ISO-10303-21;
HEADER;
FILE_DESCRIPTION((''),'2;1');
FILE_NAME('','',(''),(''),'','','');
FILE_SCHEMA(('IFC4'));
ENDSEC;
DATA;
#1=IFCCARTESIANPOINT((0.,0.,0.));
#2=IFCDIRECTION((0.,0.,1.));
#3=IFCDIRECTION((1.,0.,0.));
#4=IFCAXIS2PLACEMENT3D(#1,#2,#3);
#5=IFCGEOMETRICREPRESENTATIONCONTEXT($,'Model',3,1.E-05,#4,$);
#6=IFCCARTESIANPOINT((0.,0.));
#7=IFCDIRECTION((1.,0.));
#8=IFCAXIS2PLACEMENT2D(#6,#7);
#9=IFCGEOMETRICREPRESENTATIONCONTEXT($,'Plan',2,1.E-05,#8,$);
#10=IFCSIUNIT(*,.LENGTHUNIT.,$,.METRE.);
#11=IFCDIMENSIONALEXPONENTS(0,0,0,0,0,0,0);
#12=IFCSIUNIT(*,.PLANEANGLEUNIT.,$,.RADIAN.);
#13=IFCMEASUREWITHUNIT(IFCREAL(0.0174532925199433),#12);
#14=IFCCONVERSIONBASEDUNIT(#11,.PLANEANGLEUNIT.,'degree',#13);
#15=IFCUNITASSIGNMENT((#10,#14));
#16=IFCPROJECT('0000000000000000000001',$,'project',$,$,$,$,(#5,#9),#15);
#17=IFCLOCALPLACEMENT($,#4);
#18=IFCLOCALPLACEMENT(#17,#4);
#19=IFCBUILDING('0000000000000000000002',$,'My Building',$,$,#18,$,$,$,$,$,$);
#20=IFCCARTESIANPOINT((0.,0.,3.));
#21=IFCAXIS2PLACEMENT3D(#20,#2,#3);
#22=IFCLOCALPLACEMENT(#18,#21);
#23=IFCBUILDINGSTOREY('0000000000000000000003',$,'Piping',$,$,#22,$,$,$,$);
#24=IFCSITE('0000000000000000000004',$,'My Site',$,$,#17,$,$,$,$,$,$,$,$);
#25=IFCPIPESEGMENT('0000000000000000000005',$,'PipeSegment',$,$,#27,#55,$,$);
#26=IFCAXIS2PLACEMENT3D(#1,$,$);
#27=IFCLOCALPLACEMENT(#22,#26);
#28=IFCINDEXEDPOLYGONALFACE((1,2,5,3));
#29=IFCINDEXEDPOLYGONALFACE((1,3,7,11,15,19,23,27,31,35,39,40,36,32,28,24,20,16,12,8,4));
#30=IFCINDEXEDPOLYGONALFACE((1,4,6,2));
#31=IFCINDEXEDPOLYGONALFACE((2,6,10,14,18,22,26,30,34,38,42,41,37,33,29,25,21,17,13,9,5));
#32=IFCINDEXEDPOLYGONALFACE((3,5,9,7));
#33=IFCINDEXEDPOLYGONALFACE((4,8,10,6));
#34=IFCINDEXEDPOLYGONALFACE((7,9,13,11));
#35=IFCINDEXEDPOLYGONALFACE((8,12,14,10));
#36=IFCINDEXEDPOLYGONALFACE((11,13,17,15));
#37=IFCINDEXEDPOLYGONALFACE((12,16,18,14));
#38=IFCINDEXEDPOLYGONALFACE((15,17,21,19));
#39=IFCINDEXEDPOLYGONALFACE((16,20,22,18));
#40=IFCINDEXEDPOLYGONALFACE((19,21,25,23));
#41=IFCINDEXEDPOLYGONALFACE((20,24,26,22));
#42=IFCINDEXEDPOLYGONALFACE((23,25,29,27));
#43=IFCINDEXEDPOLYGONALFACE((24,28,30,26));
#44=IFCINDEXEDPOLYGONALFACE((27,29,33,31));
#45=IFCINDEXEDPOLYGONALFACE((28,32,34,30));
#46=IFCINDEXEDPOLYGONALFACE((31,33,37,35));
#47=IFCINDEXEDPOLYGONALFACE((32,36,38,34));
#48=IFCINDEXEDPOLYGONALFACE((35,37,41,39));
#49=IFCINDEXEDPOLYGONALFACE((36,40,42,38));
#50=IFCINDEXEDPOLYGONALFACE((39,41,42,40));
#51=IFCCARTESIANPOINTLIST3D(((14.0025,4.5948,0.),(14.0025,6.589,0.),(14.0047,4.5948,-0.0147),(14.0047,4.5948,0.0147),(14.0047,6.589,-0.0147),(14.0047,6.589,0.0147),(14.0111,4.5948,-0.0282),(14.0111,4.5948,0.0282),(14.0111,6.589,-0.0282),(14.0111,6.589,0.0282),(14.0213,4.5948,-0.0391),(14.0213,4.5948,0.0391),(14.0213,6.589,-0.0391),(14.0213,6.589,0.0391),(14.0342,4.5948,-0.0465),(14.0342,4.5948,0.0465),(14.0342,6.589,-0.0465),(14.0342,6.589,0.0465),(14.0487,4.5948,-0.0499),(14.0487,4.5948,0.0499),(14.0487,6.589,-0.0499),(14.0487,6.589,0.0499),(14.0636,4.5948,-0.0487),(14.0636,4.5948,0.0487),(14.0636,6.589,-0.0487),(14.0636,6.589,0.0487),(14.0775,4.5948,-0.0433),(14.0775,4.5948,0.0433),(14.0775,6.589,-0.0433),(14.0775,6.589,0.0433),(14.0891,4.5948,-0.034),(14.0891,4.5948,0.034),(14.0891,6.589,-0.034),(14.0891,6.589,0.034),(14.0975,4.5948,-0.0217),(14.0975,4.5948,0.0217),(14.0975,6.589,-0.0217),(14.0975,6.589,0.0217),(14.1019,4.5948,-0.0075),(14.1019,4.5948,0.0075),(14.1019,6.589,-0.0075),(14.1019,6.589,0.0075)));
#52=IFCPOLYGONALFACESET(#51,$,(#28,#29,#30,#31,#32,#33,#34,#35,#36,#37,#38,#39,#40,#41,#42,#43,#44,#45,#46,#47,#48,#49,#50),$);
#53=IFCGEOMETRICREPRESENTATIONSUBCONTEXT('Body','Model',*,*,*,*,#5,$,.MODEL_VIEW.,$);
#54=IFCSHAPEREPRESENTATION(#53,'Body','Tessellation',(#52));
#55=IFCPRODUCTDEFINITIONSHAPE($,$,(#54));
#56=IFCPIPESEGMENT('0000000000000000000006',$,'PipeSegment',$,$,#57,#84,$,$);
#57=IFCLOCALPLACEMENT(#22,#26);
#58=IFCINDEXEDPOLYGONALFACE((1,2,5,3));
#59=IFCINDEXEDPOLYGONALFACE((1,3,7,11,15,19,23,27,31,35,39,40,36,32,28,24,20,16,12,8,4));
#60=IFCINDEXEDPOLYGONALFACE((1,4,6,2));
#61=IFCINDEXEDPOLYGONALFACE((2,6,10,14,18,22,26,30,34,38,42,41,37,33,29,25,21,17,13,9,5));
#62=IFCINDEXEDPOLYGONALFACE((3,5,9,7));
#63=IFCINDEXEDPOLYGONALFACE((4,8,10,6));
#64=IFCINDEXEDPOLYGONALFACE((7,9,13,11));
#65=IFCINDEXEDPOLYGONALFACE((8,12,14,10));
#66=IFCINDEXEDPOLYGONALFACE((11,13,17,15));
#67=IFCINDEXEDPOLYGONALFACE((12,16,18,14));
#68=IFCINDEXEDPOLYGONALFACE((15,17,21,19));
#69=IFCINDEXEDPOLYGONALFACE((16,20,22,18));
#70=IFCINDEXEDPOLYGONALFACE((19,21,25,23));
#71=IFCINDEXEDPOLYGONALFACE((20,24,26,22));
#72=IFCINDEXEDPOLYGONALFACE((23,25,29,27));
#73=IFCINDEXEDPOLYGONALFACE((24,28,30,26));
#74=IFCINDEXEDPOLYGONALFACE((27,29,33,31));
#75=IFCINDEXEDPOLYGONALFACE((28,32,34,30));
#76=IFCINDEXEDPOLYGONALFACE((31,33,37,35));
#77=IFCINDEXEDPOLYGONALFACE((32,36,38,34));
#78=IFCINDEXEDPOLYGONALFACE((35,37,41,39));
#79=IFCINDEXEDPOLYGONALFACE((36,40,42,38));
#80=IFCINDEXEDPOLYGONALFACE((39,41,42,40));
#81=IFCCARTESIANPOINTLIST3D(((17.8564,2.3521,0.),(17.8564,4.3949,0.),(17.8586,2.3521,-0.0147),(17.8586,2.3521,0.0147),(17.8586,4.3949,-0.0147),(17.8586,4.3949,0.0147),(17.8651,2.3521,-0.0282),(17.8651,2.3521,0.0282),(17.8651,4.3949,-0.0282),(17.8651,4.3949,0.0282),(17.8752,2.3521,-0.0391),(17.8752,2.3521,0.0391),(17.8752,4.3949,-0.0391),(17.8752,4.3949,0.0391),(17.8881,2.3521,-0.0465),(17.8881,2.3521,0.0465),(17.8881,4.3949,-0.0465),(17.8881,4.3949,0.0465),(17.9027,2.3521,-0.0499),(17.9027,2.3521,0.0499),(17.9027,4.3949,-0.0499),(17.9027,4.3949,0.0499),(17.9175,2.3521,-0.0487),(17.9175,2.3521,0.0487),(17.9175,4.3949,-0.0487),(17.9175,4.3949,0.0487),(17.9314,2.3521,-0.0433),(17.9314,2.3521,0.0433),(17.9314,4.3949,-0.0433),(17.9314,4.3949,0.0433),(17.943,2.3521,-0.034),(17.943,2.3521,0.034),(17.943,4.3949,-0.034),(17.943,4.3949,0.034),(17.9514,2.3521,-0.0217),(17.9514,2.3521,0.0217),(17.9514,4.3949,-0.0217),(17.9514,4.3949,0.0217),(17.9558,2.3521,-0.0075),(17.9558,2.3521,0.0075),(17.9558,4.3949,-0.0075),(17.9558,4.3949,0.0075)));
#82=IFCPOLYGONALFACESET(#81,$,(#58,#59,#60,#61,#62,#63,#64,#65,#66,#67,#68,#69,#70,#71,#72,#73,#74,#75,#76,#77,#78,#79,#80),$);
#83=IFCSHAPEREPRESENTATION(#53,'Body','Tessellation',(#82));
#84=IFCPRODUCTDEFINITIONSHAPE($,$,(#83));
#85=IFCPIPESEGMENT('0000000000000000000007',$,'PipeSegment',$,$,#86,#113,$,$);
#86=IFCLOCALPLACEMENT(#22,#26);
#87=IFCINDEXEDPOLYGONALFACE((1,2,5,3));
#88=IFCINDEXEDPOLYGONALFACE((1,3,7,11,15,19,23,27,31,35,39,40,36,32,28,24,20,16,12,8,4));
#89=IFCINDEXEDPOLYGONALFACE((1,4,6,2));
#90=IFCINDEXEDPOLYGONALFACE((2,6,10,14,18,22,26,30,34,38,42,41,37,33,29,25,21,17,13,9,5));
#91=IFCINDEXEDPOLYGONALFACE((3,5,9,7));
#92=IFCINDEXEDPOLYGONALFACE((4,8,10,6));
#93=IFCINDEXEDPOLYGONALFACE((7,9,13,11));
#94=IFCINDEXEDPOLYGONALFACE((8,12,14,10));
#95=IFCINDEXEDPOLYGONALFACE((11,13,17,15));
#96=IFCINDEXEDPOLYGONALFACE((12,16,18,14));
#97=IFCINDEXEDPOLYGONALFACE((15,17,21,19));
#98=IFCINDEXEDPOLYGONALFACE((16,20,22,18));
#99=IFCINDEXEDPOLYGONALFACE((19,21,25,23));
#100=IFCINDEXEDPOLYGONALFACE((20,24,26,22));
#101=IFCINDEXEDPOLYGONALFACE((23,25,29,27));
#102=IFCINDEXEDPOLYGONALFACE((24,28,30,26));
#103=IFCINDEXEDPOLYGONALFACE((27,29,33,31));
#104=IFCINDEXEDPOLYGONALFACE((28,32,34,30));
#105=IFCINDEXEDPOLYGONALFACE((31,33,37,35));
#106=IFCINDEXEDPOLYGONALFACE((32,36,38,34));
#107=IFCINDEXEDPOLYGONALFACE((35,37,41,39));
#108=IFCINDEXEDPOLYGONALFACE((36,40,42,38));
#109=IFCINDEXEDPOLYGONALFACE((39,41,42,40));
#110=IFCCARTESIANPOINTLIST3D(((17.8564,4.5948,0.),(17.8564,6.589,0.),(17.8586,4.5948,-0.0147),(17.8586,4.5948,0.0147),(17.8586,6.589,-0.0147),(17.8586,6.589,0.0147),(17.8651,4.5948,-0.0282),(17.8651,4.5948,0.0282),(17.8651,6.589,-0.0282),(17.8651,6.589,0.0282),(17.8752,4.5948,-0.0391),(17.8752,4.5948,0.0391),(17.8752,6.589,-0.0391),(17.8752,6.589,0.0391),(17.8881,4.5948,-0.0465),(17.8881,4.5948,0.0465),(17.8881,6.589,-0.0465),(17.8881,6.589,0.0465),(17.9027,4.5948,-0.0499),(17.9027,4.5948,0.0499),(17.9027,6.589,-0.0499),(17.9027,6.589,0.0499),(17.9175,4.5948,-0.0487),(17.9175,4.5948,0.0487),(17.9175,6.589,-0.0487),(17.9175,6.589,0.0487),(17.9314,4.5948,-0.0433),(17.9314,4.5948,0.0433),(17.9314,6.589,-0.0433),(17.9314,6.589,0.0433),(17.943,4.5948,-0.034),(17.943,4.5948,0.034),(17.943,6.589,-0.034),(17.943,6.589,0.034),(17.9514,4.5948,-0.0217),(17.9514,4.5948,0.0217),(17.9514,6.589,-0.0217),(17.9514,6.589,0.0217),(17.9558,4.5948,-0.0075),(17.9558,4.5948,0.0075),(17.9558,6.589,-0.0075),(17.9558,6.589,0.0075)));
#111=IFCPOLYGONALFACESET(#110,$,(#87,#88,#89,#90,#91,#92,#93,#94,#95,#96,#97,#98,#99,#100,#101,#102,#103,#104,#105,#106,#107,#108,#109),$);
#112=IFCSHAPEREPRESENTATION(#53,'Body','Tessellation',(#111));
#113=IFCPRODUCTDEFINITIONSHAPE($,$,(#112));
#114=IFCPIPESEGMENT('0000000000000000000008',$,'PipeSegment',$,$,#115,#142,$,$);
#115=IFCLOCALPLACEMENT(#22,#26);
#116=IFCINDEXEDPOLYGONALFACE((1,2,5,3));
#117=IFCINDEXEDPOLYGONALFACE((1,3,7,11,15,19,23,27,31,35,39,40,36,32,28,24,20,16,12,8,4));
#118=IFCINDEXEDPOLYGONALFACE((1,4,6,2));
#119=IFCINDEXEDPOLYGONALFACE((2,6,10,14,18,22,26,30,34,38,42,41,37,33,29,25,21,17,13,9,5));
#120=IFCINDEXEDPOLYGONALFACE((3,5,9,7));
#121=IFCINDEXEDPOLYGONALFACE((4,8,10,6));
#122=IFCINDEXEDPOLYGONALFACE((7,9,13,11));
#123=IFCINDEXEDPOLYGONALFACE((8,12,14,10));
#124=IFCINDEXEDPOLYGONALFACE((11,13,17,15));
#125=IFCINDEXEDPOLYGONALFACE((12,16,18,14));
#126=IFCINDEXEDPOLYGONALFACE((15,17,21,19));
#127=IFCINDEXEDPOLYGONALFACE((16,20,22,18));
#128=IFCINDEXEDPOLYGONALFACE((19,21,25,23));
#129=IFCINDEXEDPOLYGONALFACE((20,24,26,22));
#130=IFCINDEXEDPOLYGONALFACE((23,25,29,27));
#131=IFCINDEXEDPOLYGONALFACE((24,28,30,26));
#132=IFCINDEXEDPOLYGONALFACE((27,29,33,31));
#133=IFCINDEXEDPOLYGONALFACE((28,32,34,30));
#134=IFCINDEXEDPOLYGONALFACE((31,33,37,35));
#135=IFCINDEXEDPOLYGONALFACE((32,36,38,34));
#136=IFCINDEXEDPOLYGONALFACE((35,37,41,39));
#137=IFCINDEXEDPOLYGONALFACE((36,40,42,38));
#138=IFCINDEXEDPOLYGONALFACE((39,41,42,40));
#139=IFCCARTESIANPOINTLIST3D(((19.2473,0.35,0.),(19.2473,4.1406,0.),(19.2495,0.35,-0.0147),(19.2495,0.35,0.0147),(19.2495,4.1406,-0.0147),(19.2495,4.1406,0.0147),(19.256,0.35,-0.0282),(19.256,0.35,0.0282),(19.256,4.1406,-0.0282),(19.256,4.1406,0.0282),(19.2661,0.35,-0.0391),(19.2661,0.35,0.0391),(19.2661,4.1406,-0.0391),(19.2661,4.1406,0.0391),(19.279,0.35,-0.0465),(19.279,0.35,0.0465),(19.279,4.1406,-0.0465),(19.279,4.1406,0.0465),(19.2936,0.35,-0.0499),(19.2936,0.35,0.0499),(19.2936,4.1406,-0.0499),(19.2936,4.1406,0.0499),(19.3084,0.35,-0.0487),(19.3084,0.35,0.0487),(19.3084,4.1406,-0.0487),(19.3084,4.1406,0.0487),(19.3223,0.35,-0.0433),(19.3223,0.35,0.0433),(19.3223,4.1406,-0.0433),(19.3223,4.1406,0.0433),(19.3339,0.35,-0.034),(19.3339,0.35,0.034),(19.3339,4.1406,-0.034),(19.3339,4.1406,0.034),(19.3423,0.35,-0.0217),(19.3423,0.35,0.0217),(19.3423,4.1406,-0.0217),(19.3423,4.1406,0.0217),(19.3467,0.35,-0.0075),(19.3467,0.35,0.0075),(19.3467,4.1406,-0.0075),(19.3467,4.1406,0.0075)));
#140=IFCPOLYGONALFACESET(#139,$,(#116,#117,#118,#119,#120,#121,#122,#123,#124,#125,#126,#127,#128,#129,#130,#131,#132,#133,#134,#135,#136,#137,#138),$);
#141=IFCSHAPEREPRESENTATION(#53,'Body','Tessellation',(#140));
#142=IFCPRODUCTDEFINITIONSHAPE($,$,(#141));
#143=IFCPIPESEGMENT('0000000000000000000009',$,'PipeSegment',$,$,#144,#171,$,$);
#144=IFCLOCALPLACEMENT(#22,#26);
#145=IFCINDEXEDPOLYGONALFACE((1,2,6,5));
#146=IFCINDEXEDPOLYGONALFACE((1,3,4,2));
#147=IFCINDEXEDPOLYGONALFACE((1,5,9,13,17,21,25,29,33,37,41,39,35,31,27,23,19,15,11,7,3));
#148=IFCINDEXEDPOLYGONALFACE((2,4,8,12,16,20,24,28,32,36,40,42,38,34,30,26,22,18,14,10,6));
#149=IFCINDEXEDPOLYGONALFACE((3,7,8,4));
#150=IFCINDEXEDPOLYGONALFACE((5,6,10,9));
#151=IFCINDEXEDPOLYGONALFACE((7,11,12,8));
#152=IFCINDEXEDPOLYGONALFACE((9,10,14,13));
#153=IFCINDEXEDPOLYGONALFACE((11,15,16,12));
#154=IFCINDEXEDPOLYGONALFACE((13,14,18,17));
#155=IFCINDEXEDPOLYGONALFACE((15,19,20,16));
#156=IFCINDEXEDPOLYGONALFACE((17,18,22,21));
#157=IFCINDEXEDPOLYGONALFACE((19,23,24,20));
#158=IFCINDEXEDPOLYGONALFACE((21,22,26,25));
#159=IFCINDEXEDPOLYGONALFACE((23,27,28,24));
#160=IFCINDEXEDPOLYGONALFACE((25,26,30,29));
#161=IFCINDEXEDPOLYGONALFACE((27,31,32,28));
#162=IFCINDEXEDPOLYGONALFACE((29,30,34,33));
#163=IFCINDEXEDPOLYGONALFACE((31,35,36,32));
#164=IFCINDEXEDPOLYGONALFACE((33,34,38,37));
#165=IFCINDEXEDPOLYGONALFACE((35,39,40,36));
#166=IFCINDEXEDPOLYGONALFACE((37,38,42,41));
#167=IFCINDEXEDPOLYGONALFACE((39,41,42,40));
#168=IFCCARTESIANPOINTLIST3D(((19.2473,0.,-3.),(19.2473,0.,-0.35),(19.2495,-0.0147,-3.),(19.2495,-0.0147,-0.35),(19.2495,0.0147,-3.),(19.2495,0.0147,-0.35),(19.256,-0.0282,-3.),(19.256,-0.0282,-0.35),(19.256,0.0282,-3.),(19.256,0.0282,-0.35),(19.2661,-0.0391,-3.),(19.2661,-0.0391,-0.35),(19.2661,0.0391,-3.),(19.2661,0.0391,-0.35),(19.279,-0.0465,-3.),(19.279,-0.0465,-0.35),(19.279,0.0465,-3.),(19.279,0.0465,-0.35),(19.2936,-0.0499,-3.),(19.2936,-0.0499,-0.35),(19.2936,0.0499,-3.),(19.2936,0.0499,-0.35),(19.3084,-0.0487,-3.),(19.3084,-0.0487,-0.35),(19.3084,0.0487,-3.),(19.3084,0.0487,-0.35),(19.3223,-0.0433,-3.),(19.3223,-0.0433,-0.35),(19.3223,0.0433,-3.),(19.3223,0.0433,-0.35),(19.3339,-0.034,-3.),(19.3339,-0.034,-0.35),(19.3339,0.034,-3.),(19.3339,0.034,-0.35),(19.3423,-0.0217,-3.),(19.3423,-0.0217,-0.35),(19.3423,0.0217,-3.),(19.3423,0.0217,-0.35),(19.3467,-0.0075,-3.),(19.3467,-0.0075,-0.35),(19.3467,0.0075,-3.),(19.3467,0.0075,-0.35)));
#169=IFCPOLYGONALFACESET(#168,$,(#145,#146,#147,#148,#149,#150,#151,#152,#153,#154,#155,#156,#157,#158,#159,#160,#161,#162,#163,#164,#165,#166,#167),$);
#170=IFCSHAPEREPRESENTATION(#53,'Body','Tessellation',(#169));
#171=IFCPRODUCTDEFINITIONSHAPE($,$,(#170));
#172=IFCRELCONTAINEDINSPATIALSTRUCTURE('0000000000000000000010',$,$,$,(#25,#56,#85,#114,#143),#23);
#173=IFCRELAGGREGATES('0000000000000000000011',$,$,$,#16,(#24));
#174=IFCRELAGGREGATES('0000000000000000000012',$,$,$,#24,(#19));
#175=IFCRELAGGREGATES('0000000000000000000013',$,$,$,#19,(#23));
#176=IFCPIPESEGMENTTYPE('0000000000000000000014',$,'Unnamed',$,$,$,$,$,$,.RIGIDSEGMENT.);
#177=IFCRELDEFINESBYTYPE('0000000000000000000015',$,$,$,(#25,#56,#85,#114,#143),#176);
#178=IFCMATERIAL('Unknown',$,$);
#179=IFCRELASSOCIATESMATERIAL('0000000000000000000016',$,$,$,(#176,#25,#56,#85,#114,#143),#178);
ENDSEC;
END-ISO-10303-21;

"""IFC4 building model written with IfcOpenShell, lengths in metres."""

from ifc_helpers import new_model, entity, si_unit, converted_unit, frame, origin_with_axes, origin_2d_with_axis, place, context, subcontext, project, spatial, circle, extrude, material, material_profile, profile_set, profile_usage, type_object, element, save


model = new_model("IFC4")

# Units and contexts
model_context = context("Model", 3, precision=1e-05, world=origin_with_axes())
plan_context = context("Plan", 2, precision=1e-05, world=origin_2d_with_axis())
body_context = subcontext(model_context, "Body", "Model", "MODEL_VIEW")
ifc_project = project(units=[si_unit("LENGTHUNIT", "METRE"), converted_unit("PLANEANGLEUNIT", "degree", entity("IfcReal", 0.0174532925199433), si_unit("PLANEANGLEUNIT", "RADIAN"), dimensions=[0, 0, 0, 0, 0, 0, 0])], contexts=[model_context, plan_context])

# Site, building, storey
site_placement = place(None, origin_with_axes())
site = spatial("IfcSite", under=ifc_project, at=site_placement, Name="My Site")
building_placement = place(site_placement, origin_with_axes())
building = spatial("IfcBuilding", under=site, at=building_placement, Name="My Building")
storey_placement = place(building_placement, frame((0.0, 0.0, 3.0), z_axis=(0.0, 0.0, 1.0), x_axis=(1.0, 0.0, 0.0)))
storey = spatial("IfcBuildingStorey", under=building, at=storey_placement, Name="Piping")

# Pipe segments
ifc_material = material(Name="Unknown")
ifc_material_profile_1 = material_profile(ifc_material, circle(Radius=0.05))
ifc_profile_set_1 = profile_set([ifc_material_profile_1])
pipe_segment_type = type_object("IfcPipeSegmentType", Name="Unnamed", PredefinedType="RIGIDSEGMENT", material=ifc_profile_set_1)
ifc_profile_usage_1 = profile_usage(ifc_profile_set_1, cardinal=5)
pipe_segment_1_placement = place(storey_placement, frame((14.0525, 4.5948, 0.0), z_axis=(0.0, 1.0, 0.0), x_axis=(-1.0, 0.0, 0.0)))
element("IfcPipeSegment", 1, at=pipe_segment_1_placement, inside=storey, type_object=pipe_segment_type, material=ifc_profile_usage_1, Name="PipeSegment", context=body_context, shape_type="SweptSolid", body=[
    extrude(circle(Radius=0.05), origin_with_axes(), (0.0, 0.0, 1.0), 1.9942),
])
ifc_profile_usage_2 = profile_usage(ifc_profile_set_1, cardinal=5)
pipe_segment_2_placement = place(storey_placement, frame((17.9064, 2.3521, 0.0), z_axis=(0.0, 1.0, 0.0), x_axis=(-1.0, 0.0, 0.0)))
element("IfcPipeSegment", 2, at=pipe_segment_2_placement, inside=storey, type_object=pipe_segment_type, material=ifc_profile_usage_2, Name="PipeSegment", context=body_context, shape_type="SweptSolid", body=[
    extrude(circle(Radius=0.05), origin_with_axes(), (0.0, 0.0, 1.0), 2.0428),
])
ifc_profile_usage_3 = profile_usage(ifc_profile_set_1, cardinal=5)
pipe_segment_3_placement = place(storey_placement, frame((17.9064, 4.5948, 0.0), z_axis=(0.0, 1.0, 0.0), x_axis=(-1.0, 0.0, 0.0)))
element("IfcPipeSegment", 3, at=pipe_segment_3_placement, inside=storey, type_object=pipe_segment_type, material=ifc_profile_usage_3, Name="PipeSegment", context=body_context, shape_type="SweptSolid", body=[
    extrude(circle(Radius=0.05), origin_with_axes(), (0.0, 0.0, 1.0), 1.9942),
])
ifc_profile_usage_4 = profile_usage(ifc_profile_set_1, cardinal=5)
pipe_segment_4_placement = place(storey_placement, frame((19.2973, 0.35, 0.0), z_axis=(0.0, 1.0, 0.0), x_axis=(-1.0, 0.0, 0.0)))
element("IfcPipeSegment", 4, at=pipe_segment_4_placement, inside=storey, type_object=pipe_segment_type, material=ifc_profile_usage_4, Name="PipeSegment", context=body_context, shape_type="SweptSolid", body=[
    extrude(circle(Radius=0.05), origin_with_axes(), (0.0, 0.0, 1.0), 3.7906),
])
ifc_profile_usage_5 = profile_usage(ifc_profile_set_1, cardinal=5)
pipe_segment_5_placement = place(storey_placement, frame((19.2973, 0.0, -0.35), z_axis=(0.0, 0.0, -1.0), x_axis=(-1.0, 0.0, 0.0)))
element("IfcPipeSegment", 5, at=pipe_segment_5_placement, inside=storey, type_object=pipe_segment_type, material=ifc_profile_usage_5, Name="PipeSegment", context=body_context, shape_type="SweptSolid", body=[
    extrude(circle(Radius=0.05), origin_with_axes(), (0.0, 0.0, 1.0), 2.65),
])

save(model, "model.ifc")
